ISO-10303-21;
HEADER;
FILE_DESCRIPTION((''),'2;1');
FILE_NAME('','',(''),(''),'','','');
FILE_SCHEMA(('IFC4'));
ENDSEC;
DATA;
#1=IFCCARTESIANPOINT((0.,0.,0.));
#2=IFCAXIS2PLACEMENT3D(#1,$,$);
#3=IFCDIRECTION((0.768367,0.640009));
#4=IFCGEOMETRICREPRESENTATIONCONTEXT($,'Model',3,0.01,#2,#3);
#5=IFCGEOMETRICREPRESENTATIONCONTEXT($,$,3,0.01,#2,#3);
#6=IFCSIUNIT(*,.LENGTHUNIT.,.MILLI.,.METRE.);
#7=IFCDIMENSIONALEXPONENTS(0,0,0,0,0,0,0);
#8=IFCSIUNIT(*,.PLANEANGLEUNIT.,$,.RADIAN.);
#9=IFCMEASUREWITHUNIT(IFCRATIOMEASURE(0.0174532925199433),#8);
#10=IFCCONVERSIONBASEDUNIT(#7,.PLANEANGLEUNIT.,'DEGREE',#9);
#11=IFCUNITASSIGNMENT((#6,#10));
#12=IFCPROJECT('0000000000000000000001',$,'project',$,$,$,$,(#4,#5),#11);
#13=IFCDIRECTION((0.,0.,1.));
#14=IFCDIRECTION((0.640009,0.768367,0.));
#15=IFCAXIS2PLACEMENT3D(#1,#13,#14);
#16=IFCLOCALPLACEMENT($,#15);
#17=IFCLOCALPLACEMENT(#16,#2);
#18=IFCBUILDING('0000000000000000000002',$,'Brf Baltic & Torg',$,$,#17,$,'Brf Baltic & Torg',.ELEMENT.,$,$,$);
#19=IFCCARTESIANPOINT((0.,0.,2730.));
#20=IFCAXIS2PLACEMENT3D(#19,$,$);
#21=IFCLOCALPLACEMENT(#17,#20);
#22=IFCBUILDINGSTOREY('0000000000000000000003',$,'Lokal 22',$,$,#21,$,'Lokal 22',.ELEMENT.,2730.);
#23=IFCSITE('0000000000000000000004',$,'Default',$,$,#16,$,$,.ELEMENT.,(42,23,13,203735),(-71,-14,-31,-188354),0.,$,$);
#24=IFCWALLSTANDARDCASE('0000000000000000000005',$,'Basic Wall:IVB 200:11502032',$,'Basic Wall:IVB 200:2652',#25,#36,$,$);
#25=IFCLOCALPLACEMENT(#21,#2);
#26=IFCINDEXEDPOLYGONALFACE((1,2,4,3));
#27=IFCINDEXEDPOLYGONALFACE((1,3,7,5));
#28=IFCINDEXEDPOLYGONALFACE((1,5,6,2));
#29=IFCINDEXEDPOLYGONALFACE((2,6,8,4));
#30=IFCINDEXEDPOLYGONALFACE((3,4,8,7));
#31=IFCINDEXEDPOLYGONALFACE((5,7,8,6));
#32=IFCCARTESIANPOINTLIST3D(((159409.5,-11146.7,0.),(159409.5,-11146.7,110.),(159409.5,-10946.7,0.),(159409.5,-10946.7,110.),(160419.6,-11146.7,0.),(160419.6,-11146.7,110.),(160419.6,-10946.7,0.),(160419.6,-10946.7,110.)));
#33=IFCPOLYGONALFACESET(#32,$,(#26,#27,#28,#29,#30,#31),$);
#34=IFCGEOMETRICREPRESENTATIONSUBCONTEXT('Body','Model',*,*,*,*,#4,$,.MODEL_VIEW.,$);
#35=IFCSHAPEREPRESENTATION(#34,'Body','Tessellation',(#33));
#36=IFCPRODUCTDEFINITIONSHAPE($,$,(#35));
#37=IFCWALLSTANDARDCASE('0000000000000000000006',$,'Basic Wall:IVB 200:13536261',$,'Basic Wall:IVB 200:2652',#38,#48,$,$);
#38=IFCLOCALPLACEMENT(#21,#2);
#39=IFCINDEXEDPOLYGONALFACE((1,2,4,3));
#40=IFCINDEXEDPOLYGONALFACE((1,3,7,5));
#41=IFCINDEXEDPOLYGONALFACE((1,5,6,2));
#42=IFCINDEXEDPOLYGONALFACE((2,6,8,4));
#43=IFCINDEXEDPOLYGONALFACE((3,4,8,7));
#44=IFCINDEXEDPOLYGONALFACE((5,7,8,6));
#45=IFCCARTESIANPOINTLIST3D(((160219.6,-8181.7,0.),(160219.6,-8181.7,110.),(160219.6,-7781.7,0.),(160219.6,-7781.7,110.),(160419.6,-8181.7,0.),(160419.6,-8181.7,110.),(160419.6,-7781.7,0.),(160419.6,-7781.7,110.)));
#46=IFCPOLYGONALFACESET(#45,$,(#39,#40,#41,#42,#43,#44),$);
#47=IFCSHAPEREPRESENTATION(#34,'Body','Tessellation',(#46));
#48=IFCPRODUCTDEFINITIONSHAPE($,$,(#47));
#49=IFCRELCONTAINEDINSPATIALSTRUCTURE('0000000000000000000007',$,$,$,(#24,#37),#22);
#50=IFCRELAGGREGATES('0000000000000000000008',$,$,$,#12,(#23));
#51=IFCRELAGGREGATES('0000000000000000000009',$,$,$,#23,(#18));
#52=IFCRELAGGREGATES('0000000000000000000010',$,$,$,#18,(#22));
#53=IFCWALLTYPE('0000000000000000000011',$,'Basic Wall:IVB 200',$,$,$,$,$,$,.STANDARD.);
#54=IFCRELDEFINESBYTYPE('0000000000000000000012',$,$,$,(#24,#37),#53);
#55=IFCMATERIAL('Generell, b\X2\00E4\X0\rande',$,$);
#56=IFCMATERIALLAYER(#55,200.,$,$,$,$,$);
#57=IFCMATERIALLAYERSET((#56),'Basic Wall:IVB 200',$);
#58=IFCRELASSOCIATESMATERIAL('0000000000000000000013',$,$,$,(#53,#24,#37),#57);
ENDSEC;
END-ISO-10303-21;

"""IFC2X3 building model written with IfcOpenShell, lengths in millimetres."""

from ifc_helpers import new_model, entity, si_unit, converted_unit, direction, frame, frame_2d, origin, place, context, subcontext, project, spatial, rectangle, extrude, clip, halfspace, material, layer, layer_set, layer_usage, type_object, element, save


model = new_model("IFC2X3")

# Units and contexts
model_context = context("Model", 3, precision=0.01, world=origin(), true_north=direction((0.768367, 0.640009)))
context_of_model = context(None, 3, precision=0.01, world=origin(), true_north=direction((0.768367, 0.640009)))
body_context = subcontext(model_context, "Body", "Model", "MODEL_VIEW")
ifc_project = project(units=[si_unit("LENGTHUNIT", "METRE", prefix="MILLI"), converted_unit("PLANEANGLEUNIT", "DEGREE", entity("IfcRatioMeasure", 0.0174532925199433), si_unit("PLANEANGLEUNIT", "RADIAN"), dimensions=[0, 0, 0, 0, 0, 0, 0])], contexts=[model_context, context_of_model])

# Site, building, storey
site_placement = place(None, frame((0.0, 0.0, 0.0), z_axis=(0.0, 0.0, 1.0), x_axis=(0.640009, 0.768367, 0.0)))
site = spatial("IfcSite", under=ifc_project, at=site_placement, Name="Default", CompositionType="ELEMENT", RefLatitude=(42, 23, 13, 203735), RefLongitude=(-71, -14, -31, -188354), RefElevation=0.0)
building_placement = place(site_placement, origin())
building = spatial("IfcBuilding", under=site, at=building_placement, Name="Brf Baltic & Torg", LongName="Brf Baltic & Torg", CompositionType="ELEMENT")
storey_placement = place(building_placement, frame((0.0, 0.0, 2730.0)))
storey = spatial("IfcBuildingStorey", under=building, at=storey_placement, Name="Lokal 22", LongName="Lokal 22", CompositionType="ELEMENT", Elevation=2730.0)

# Shared definitions
ifc_material_1 = material(Name="Generell, bärande")
ifc_layer = layer(ifc_material_1, 200.0)
ifc_layer_set = layer_set([ifc_layer], Name="Basic Wall:IVB 200")
wall_type = type_object("IfcWallType", Name="Basic Wall:IVB 200", PredefinedType="STANDARD", material=ifc_layer_set)

# Walls
ifc_layer_usage_1 = layer_usage(ifc_layer_set, "AXIS2", "NEGATIVE", 100.0)
wall_1_placement = place(storey_placement, frame((159409.5, -11046.7, 0.0)))
element("IfcWallStandardCase", 1, at=wall_1_placement, inside=storey, type_object=wall_type, material=ifc_layer_usage_1, Name="Basic Wall:IVB 200:11502032", ObjectType="Basic Wall:IVB 200:2652", context=body_context, shape_type="Clipping", body=[
    clip(extrude(rectangle(XDim=1010.1, YDim=200.0, at=frame_2d((505.0, 0.0), x_axis=(-1.0, 0.0))), origin(), (0.0, 0.0, 1.0), 110.0), halfspace(frame((0.0, 0.0, -1080.0)), True)),
])
ifc_layer_usage_2 = layer_usage(ifc_layer_set, "AXIS2", "NEGATIVE", 100.0)
wall_2_placement = place(storey_placement, frame((160319.6, -8181.7, 0.0), z_axis=(0.0, 0.0, 1.0), x_axis=(0.0, 1.0, 0.0)))
element("IfcWallStandardCase", 2, at=wall_2_placement, inside=storey, type_object=wall_type, material=ifc_layer_usage_2, Name="Basic Wall:IVB 200:13536261", ObjectType="Basic Wall:IVB 200:2652", context=body_context, shape_type="Clipping", body=[
    clip(extrude(rectangle(XDim=400.0, YDim=200.0, at=frame_2d((200.0, 0.0), x_axis=(-1.0, 0.0))), origin(), (0.0, 0.0, 1.0), 110.0), halfspace(frame((0.0, 0.0, -1080.0)), True)),
])

save(model, "model.ifc")
